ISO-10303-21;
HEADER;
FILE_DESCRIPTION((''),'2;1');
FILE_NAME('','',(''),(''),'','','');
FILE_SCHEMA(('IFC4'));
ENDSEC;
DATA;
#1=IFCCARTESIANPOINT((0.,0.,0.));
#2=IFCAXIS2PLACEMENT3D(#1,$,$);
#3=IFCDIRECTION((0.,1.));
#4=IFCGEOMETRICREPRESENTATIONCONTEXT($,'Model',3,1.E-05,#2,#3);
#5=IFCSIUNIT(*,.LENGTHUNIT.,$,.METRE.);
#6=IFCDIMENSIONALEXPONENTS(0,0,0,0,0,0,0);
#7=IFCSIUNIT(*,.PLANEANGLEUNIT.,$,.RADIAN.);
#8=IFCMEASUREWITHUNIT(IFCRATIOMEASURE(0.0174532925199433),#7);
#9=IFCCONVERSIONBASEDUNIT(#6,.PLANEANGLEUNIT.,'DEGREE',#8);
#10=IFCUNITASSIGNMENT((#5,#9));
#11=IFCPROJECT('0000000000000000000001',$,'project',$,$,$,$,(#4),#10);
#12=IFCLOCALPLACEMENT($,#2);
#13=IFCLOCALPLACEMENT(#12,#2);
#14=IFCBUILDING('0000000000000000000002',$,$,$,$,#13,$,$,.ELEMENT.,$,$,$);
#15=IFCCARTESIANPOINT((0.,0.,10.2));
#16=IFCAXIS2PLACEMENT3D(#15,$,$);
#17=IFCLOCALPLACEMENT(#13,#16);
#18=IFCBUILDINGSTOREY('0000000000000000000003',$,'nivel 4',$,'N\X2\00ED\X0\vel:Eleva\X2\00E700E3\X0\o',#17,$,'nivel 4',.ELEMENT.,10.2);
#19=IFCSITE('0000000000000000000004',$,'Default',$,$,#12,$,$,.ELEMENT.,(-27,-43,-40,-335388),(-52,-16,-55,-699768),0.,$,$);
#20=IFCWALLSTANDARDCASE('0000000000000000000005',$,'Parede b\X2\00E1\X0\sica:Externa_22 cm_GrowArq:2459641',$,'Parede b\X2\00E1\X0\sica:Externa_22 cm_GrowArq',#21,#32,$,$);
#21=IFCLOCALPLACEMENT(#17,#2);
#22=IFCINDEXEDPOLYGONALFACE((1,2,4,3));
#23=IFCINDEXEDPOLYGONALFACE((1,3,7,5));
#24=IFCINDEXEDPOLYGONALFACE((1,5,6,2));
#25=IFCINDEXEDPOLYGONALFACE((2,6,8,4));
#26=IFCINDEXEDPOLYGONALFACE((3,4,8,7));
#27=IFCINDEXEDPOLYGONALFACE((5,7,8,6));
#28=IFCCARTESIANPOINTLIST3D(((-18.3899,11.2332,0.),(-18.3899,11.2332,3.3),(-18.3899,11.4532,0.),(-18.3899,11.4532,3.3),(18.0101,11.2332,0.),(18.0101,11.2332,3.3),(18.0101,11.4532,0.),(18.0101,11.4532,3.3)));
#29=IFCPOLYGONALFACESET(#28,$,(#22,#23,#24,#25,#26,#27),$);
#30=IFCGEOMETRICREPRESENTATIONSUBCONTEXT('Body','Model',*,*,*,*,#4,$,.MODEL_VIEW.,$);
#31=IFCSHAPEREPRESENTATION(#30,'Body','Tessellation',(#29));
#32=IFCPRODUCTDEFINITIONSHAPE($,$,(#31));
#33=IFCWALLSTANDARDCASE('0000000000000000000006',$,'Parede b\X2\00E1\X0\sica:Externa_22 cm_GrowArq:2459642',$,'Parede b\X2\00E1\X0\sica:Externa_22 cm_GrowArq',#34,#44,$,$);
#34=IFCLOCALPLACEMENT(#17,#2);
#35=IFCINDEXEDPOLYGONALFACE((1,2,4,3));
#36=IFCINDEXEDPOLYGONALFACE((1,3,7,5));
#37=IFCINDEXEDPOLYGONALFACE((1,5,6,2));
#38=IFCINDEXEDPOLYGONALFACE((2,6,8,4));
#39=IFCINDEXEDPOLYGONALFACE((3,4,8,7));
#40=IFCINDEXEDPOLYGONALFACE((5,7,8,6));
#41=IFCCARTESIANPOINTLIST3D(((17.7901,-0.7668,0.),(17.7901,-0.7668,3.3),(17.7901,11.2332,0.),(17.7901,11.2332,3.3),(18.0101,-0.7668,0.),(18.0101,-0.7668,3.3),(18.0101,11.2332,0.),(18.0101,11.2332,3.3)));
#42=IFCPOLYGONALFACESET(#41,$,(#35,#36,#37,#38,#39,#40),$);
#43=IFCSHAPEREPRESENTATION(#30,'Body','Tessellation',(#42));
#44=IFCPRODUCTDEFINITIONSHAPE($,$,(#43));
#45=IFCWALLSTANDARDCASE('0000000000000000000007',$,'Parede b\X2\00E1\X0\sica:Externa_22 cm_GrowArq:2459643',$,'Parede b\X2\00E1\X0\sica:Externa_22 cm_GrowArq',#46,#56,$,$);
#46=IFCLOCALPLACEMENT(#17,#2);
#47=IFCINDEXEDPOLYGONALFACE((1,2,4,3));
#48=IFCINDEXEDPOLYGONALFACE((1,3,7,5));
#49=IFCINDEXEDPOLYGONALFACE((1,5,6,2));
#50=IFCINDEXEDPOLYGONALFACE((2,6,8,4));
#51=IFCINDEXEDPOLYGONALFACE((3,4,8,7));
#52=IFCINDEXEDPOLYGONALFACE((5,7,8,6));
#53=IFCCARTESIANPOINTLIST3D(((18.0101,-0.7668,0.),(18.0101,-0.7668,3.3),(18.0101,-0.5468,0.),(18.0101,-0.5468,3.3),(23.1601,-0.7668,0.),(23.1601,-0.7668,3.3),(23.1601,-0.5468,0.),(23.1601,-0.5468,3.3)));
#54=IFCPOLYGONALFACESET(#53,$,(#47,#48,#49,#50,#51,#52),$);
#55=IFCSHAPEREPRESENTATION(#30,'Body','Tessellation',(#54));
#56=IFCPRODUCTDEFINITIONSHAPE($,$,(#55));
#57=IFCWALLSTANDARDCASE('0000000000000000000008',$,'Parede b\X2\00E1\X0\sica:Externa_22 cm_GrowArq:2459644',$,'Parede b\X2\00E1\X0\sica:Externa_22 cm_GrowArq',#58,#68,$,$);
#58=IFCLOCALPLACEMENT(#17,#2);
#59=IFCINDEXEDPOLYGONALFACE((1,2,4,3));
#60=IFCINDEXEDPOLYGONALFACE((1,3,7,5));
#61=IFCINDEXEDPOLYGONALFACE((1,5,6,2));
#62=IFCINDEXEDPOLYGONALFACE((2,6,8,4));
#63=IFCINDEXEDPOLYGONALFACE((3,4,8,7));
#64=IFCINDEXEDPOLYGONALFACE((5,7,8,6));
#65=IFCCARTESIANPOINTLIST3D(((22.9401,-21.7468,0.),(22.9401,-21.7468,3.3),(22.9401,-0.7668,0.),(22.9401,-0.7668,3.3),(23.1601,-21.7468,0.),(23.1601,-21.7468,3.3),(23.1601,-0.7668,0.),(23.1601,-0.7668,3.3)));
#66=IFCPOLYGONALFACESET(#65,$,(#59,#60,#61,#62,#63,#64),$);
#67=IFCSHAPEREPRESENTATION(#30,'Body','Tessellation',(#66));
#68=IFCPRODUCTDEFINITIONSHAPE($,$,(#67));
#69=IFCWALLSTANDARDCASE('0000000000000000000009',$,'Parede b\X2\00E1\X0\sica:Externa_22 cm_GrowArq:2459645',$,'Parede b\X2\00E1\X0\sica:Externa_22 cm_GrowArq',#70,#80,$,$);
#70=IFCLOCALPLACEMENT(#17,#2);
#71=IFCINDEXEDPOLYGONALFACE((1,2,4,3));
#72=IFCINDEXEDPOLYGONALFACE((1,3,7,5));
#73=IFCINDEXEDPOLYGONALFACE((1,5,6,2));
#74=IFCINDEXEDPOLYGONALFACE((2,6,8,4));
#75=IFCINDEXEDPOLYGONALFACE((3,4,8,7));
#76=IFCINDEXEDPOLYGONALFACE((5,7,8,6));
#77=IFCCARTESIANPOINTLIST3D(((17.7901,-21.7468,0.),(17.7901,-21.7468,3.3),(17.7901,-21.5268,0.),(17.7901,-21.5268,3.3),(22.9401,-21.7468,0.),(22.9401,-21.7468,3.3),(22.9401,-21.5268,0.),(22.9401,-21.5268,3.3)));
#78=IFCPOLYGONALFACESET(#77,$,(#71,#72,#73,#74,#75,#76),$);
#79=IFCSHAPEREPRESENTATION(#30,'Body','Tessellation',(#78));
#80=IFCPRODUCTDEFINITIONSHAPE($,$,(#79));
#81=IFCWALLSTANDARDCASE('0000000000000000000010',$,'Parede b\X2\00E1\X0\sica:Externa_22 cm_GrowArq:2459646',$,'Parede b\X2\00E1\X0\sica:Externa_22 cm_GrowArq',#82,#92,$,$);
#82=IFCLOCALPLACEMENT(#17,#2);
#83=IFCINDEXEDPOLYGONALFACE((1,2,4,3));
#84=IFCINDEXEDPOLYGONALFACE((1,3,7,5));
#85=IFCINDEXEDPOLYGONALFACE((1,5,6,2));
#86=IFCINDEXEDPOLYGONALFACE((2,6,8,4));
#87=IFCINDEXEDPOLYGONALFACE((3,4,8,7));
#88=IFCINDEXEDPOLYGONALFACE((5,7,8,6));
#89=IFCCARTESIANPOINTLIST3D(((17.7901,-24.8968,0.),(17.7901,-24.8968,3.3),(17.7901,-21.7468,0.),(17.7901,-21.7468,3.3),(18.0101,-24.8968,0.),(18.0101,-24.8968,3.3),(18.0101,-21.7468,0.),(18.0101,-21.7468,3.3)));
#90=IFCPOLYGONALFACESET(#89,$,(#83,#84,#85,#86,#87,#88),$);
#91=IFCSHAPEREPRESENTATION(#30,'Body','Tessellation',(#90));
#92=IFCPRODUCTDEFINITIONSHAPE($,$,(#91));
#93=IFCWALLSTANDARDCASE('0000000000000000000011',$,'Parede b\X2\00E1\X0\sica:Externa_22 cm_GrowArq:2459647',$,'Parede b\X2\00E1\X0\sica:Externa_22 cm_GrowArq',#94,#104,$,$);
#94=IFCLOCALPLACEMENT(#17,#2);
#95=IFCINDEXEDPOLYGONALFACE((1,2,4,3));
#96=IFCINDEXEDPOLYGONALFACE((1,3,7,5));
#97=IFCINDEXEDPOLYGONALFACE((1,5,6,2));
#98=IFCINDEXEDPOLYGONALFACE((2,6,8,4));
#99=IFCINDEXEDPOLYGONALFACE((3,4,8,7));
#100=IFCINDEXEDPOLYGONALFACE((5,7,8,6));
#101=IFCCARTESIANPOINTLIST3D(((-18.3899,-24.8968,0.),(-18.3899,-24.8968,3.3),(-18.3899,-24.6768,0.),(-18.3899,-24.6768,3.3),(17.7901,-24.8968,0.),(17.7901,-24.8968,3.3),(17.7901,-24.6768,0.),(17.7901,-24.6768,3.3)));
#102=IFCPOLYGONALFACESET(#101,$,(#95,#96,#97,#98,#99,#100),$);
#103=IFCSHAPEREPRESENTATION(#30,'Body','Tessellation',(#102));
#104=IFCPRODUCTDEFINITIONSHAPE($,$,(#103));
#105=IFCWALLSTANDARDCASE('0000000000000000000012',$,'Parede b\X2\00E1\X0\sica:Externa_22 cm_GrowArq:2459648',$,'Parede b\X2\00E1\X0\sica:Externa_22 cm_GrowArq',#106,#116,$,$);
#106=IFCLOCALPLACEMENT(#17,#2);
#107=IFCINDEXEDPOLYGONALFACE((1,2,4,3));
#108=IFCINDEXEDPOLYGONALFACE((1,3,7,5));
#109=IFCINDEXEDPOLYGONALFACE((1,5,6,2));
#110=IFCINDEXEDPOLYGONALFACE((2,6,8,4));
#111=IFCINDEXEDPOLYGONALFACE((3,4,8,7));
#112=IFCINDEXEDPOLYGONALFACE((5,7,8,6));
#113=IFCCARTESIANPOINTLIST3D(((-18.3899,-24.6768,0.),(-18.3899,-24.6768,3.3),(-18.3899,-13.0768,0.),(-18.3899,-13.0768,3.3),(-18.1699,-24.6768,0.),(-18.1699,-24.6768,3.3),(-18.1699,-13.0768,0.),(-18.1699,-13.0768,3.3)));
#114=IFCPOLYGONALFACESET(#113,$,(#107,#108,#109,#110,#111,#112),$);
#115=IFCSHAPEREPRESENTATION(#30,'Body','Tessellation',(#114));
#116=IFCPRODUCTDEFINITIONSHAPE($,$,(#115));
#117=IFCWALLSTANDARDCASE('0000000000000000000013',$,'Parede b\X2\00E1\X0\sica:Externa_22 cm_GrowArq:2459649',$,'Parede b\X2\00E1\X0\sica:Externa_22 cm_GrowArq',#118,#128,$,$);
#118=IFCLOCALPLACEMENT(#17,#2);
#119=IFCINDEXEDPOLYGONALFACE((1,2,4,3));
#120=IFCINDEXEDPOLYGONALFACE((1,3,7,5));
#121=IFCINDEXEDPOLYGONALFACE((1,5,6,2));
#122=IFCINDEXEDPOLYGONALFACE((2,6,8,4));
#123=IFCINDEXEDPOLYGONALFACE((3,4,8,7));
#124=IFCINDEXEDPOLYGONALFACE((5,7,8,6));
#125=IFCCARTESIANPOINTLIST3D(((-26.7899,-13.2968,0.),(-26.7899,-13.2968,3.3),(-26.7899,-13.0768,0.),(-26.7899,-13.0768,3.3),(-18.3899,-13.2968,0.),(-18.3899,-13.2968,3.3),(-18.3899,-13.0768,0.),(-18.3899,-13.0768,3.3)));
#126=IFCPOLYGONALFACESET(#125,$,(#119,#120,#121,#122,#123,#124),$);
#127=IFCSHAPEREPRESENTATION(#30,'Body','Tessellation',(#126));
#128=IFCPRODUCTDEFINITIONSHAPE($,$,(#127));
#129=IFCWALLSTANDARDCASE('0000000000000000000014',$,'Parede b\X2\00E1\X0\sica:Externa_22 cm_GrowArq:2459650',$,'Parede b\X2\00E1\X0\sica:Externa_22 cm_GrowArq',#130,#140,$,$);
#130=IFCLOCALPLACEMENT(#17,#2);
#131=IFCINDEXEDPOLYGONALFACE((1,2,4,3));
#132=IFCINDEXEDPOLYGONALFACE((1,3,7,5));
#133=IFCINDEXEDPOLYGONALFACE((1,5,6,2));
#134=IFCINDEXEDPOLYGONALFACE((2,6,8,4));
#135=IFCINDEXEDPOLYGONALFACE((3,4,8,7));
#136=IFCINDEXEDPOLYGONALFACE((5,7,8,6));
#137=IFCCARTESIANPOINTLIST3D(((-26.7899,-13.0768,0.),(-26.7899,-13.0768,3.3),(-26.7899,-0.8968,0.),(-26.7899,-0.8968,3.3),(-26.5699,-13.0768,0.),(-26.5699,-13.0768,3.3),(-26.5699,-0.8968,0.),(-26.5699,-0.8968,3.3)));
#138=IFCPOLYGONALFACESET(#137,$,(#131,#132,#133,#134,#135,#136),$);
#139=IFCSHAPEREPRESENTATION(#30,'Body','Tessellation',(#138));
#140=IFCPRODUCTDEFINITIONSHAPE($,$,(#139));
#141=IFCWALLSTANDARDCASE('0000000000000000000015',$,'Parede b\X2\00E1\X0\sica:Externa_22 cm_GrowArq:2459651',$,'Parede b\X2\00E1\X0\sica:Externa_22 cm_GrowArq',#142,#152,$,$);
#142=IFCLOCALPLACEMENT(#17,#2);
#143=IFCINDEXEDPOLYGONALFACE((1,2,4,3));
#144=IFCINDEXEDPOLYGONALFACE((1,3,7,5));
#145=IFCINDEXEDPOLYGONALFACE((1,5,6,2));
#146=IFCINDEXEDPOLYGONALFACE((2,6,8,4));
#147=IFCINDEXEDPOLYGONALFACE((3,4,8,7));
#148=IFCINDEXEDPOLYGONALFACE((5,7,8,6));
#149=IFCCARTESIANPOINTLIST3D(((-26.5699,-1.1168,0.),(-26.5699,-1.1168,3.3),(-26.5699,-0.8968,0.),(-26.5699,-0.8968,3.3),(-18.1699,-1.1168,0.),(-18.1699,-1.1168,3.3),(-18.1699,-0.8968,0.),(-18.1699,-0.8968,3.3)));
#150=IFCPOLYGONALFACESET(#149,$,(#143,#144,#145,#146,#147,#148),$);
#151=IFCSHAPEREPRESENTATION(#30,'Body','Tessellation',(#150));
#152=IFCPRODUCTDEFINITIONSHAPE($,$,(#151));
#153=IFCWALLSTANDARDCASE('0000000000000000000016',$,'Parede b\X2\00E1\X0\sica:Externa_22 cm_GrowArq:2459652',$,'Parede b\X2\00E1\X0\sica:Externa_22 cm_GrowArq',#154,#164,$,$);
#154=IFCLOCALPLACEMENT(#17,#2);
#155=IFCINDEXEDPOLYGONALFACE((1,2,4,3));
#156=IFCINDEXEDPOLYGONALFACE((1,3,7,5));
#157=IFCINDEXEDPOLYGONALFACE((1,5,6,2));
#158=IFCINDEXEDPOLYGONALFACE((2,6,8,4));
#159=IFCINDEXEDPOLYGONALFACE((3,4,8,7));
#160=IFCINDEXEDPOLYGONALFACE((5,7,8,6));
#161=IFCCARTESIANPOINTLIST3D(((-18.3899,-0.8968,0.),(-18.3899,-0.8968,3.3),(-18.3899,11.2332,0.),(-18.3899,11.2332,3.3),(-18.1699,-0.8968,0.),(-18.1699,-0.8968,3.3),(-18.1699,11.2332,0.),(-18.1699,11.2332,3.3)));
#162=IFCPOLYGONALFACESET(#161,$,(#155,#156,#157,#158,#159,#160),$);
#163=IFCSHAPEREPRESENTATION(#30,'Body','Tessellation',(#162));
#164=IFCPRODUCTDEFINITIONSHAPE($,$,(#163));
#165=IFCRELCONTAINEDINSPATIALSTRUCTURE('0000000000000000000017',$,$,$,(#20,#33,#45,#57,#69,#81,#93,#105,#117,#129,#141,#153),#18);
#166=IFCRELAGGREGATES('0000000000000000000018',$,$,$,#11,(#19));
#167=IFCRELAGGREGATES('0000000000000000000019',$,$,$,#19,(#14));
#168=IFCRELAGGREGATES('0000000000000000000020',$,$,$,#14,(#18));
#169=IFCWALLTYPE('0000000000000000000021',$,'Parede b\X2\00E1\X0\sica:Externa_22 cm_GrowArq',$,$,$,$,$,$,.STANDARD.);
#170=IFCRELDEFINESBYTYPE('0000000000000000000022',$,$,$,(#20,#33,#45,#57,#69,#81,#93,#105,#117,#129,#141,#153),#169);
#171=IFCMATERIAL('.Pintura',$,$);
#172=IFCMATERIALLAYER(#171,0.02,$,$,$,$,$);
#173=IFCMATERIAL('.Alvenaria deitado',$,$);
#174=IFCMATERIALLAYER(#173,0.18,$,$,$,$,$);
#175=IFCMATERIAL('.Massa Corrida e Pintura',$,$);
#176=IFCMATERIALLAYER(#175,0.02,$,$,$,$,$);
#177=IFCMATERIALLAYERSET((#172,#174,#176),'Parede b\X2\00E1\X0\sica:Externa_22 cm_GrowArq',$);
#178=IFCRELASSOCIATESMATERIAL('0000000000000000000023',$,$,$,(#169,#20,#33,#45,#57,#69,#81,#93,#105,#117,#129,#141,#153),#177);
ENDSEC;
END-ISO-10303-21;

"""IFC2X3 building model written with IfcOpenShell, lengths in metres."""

from ifc_helpers import new_model, entity, si_unit, converted_unit, direction, frame, frame_2d, origin, place, context, subcontext, project, spatial, rectangle, extrude, material, layer, layer_set, layer_usage, type_object, element, save


model = new_model("IFC2X3")

# Units and contexts
model_context = context("Model", 3, precision=1e-05, world=origin(), true_north=direction((0.0, 1.0)))
body_context = subcontext(model_context, "Body", "Model", "MODEL_VIEW")
ifc_project = project(units=[si_unit("LENGTHUNIT", "METRE"), converted_unit("PLANEANGLEUNIT", "DEGREE", entity("IfcRatioMeasure", 0.0174532925199433), si_unit("PLANEANGLEUNIT", "RADIAN"), dimensions=[0, 0, 0, 0, 0, 0, 0])], contexts=[model_context])

# Site, building, storey
site_placement = place(None, origin())
site = spatial("IfcSite", under=ifc_project, at=site_placement, Name="Default", CompositionType="ELEMENT", RefLatitude=(-27, -43, -40, -335388), RefLongitude=(-52, -16, -55, -699768), RefElevation=0.0)
building_placement = place(site_placement, origin())
building = spatial("IfcBuilding", under=site, at=building_placement, CompositionType="ELEMENT")
storey_placement = place(building_placement, frame((0.0, 0.0, 10.2)))
storey = spatial("IfcBuildingStorey", under=building, at=storey_placement, Name="nivel 4", ObjectType="Nível:Elevação", LongName="nivel 4", CompositionType="ELEMENT", Elevation=10.2)

# Walls
ifc_material_1 = material(Name=".Pintura")
ifc_layer_1 = layer(ifc_material_1, 0.02)
ifc_material_2 = material(Name=".Alvenaria deitado")
ifc_layer_2 = layer(ifc_material_2, 0.18)
ifc_material_3 = material(Name=".Massa Corrida e Pintura")
ifc_layer_3 = layer(ifc_material_3, 0.02)
ifc_layer_set_1 = layer_set([ifc_layer_1, ifc_layer_2, ifc_layer_3], Name="Parede básica:Externa_22 cm_GrowArq")
ifc_layer_usage_1 = layer_usage(ifc_layer_set_1, "AXIS2", "NEGATIVE", 0.11)
wall_type = type_object("IfcWallType", Name="Parede básica:Externa_22 cm_GrowArq", PredefinedType="STANDARD", material=ifc_layer_set_1)
wall_1_placement = place(storey_placement, frame((-18.3899, 11.3432, 0.0)))
element("IfcWallStandardCase", 1, at=wall_1_placement, inside=storey, type_object=wall_type, material=ifc_layer_usage_1, Name="Parede básica:Externa_22 cm_GrowArq:2459641", ObjectType="Parede básica:Externa_22 cm_GrowArq", context=body_context, shape_type="SweptSolid", body=[
    extrude(rectangle(XDim=36.4, YDim=0.22, at=frame_2d((18.2, 0.0), x_axis=(-1.0, 0.0))), origin(), (0.0, 0.0, 1.0), 3.3),
])
ifc_layer_usage_2 = layer_usage(ifc_layer_set_1, "AXIS2", "NEGATIVE", 0.11)
wall_2_placement = place(storey_placement, frame((17.9001, 11.2332, 0.0), z_axis=(0.0, 0.0, 1.0), x_axis=(0.0, -1.0, 0.0)))
element("IfcWallStandardCase", 2, at=wall_2_placement, inside=storey, type_object=wall_type, material=ifc_layer_usage_2, Name="Parede básica:Externa_22 cm_GrowArq:2459642", ObjectType="Parede básica:Externa_22 cm_GrowArq", context=body_context, shape_type="SweptSolid", body=[
    extrude(rectangle(XDim=12.0, YDim=0.22, at=frame_2d((6.0, 0.0), x_axis=(-1.0, 0.0))), origin(), (0.0, 0.0, 1.0), 3.3),
])
ifc_layer_usage_3 = layer_usage(ifc_layer_set_1, "AXIS2", "NEGATIVE", 0.11)
wall_3_placement = place(storey_placement, frame((18.0101, -0.6568, 0.0)))
element("IfcWallStandardCase", 3, at=wall_3_placement, inside=storey, type_object=wall_type, material=ifc_layer_usage_3, Name="Parede básica:Externa_22 cm_GrowArq:2459643", ObjectType="Parede básica:Externa_22 cm_GrowArq", context=body_context, shape_type="SweptSolid", body=[
    extrude(rectangle(XDim=5.15, YDim=0.22, at=frame_2d((2.575, 0.0), x_axis=(-1.0, 0.0))), origin(), (0.0, 0.0, 1.0), 3.3),
])
ifc_layer_usage_4 = layer_usage(ifc_layer_set_1, "AXIS2", "NEGATIVE", 0.11)
wall_4_placement = place(storey_placement, frame((23.0501, -0.7668, 0.0), z_axis=(0.0, 0.0, 1.0), x_axis=(0.0, -1.0, 0.0)))
element("IfcWallStandardCase", 4, at=wall_4_placement, inside=storey, type_object=wall_type, material=ifc_layer_usage_4, Name="Parede básica:Externa_22 cm_GrowArq:2459644", ObjectType="Parede básica:Externa_22 cm_GrowArq", context=body_context, shape_type="SweptSolid", body=[
    extrude(rectangle(XDim=20.98, YDim=0.22, at=frame_2d((10.49, 0.0), x_axis=(-1.0, 0.0))), origin(), (0.0, 0.0, 1.0), 3.3),
])
ifc_layer_usage_5 = layer_usage(ifc_layer_set_1, "AXIS2", "NEGATIVE", 0.11)
wall_5_placement = place(storey_placement, frame((22.9401, -21.6368, 0.0), z_axis=(0.0, 0.0, 1.0), x_axis=(-1.0, 0.0, 0.0)))
element("IfcWallStandardCase", 5, at=wall_5_placement, inside=storey, type_object=wall_type, material=ifc_layer_usage_5, Name="Parede básica:Externa_22 cm_GrowArq:2459645", ObjectType="Parede básica:Externa_22 cm_GrowArq", context=body_context, shape_type="SweptSolid", body=[
    extrude(rectangle(XDim=5.15, YDim=0.22, at=frame_2d((2.575, 0.0), x_axis=(-1.0, 0.0))), origin(), (0.0, 0.0, 1.0), 3.3),
])
ifc_layer_usage_6 = layer_usage(ifc_layer_set_1, "AXIS2", "NEGATIVE", 0.11)
wall_6_placement = place(storey_placement, frame((17.9001, -21.7468, 0.0), z_axis=(0.0, 0.0, 1.0), x_axis=(0.0, -1.0, 0.0)))
element("IfcWallStandardCase", 6, at=wall_6_placement, inside=storey, type_object=wall_type, material=ifc_layer_usage_6, Name="Parede básica:Externa_22 cm_GrowArq:2459646", ObjectType="Parede básica:Externa_22 cm_GrowArq", context=body_context, shape_type="SweptSolid", body=[
    extrude(rectangle(XDim=3.15, YDim=0.22, at=frame_2d((1.575, 0.0), x_axis=(-1.0, 0.0))), origin(), (0.0, 0.0, 1.0), 3.3),
])
ifc_layer_usage_7 = layer_usage(ifc_layer_set_1, "AXIS2", "NEGATIVE", 0.11)
wall_7_placement = place(storey_placement, frame((17.7901, -24.7868, 0.0), z_axis=(0.0, 0.0, 1.0), x_axis=(-1.0, 0.0, 0.0)))
element("IfcWallStandardCase", 7, at=wall_7_placement, inside=storey, type_object=wall_type, material=ifc_layer_usage_7, Name="Parede básica:Externa_22 cm_GrowArq:2459647", ObjectType="Parede básica:Externa_22 cm_GrowArq", context=body_context, shape_type="SweptSolid", body=[
    extrude(rectangle(XDim=36.18, YDim=0.22, at=frame_2d((18.09, 0.0), x_axis=(-1.0, 0.0))), origin(), (0.0, 0.0, 1.0), 3.3),
])
ifc_layer_usage_8 = layer_usage(ifc_layer_set_1, "AXIS2", "NEGATIVE", 0.11)
wall_8_placement = place(storey_placement, frame((-18.2799, -24.6768, 0.0), z_axis=(0.0, 0.0, 1.0), x_axis=(0.0, 1.0, 0.0)))
element("IfcWallStandardCase", 8, at=wall_8_placement, inside=storey, type_object=wall_type, material=ifc_layer_usage_8, Name="Parede básica:Externa_22 cm_GrowArq:2459648", ObjectType="Parede básica:Externa_22 cm_GrowArq", context=body_context, shape_type="SweptSolid", body=[
    extrude(rectangle(XDim=11.6, YDim=0.22, at=frame_2d((5.8, 0.0), x_axis=(-1.0, 0.0))), origin(), (0.0, 0.0, 1.0), 3.3),
])
ifc_layer_usage_9 = layer_usage(ifc_layer_set_1, "AXIS2", "NEGATIVE", 0.11)
wall_9_placement = place(storey_placement, frame((-18.3899, -13.1868, 0.0), z_axis=(0.0, 0.0, 1.0), x_axis=(-1.0, 0.0, 0.0)))
element("IfcWallStandardCase", 9, at=wall_9_placement, inside=storey, type_object=wall_type, material=ifc_layer_usage_9, Name="Parede básica:Externa_22 cm_GrowArq:2459649", ObjectType="Parede básica:Externa_22 cm_GrowArq", context=body_context, shape_type="SweptSolid", body=[
    extrude(rectangle(XDim=8.4, YDim=0.22, at=frame_2d((4.2, 0.0), x_axis=(-1.0, 0.0))), origin(), (0.0, 0.0, 1.0), 3.3),
])
ifc_layer_usage_10 = layer_usage(ifc_layer_set_1, "AXIS2", "NEGATIVE", 0.11)
wall_10_placement = place(storey_placement, frame((-26.6799, -13.0768, 0.0), z_axis=(0.0, 0.0, 1.0), x_axis=(0.0, 1.0, 0.0)))
element("IfcWallStandardCase", 10, at=wall_10_placement, inside=storey, type_object=wall_type, material=ifc_layer_usage_10, Name="Parede básica:Externa_22 cm_GrowArq:2459650", ObjectType="Parede básica:Externa_22 cm_GrowArq", context=body_context, shape_type="SweptSolid", body=[
    extrude(rectangle(XDim=12.18, YDim=0.22, at=frame_2d((6.09, 0.0), x_axis=(-1.0, 0.0))), origin(), (0.0, 0.0, 1.0), 3.3),
])
ifc_layer_usage_11 = layer_usage(ifc_layer_set_1, "AXIS2", "NEGATIVE", 0.11)
wall_11_placement = place(storey_placement, frame((-26.5699, -1.0068, 0.0)))
element("IfcWallStandardCase", 11, at=wall_11_placement, inside=storey, type_object=wall_type, material=ifc_layer_usage_11, Name="Parede básica:Externa_22 cm_GrowArq:2459651", ObjectType="Parede básica:Externa_22 cm_GrowArq", context=body_context, shape_type="SweptSolid", body=[
    extrude(rectangle(XDim=8.4, YDim=0.22, at=frame_2d((4.2, 0.0), x_axis=(-1.0, 0.0))), origin(), (0.0, 0.0, 1.0), 3.3),
])
ifc_layer_usage_12 = layer_usage(ifc_layer_set_1, "AXIS2", "NEGATIVE", 0.11)
wall_12_placement = place(storey_placement, frame((-18.2799, -0.8968, 0.0), z_axis=(0.0, 0.0, 1.0), x_axis=(0.0, 1.0, 0.0)))
element("IfcWallStandardCase", 12, at=wall_12_placement, inside=storey, type_object=wall_type, material=ifc_layer_usage_12, Name="Parede básica:Externa_22 cm_GrowArq:2459652", ObjectType="Parede básica:Externa_22 cm_GrowArq", context=body_context, shape_type="SweptSolid", body=[
    extrude(rectangle(XDim=12.13, YDim=0.22, at=frame_2d((6.065, 0.0), x_axis=(-1.0, 0.0))), origin(), (0.0, 0.0, 1.0), 3.3),
])

save(model, "model.ifc")
